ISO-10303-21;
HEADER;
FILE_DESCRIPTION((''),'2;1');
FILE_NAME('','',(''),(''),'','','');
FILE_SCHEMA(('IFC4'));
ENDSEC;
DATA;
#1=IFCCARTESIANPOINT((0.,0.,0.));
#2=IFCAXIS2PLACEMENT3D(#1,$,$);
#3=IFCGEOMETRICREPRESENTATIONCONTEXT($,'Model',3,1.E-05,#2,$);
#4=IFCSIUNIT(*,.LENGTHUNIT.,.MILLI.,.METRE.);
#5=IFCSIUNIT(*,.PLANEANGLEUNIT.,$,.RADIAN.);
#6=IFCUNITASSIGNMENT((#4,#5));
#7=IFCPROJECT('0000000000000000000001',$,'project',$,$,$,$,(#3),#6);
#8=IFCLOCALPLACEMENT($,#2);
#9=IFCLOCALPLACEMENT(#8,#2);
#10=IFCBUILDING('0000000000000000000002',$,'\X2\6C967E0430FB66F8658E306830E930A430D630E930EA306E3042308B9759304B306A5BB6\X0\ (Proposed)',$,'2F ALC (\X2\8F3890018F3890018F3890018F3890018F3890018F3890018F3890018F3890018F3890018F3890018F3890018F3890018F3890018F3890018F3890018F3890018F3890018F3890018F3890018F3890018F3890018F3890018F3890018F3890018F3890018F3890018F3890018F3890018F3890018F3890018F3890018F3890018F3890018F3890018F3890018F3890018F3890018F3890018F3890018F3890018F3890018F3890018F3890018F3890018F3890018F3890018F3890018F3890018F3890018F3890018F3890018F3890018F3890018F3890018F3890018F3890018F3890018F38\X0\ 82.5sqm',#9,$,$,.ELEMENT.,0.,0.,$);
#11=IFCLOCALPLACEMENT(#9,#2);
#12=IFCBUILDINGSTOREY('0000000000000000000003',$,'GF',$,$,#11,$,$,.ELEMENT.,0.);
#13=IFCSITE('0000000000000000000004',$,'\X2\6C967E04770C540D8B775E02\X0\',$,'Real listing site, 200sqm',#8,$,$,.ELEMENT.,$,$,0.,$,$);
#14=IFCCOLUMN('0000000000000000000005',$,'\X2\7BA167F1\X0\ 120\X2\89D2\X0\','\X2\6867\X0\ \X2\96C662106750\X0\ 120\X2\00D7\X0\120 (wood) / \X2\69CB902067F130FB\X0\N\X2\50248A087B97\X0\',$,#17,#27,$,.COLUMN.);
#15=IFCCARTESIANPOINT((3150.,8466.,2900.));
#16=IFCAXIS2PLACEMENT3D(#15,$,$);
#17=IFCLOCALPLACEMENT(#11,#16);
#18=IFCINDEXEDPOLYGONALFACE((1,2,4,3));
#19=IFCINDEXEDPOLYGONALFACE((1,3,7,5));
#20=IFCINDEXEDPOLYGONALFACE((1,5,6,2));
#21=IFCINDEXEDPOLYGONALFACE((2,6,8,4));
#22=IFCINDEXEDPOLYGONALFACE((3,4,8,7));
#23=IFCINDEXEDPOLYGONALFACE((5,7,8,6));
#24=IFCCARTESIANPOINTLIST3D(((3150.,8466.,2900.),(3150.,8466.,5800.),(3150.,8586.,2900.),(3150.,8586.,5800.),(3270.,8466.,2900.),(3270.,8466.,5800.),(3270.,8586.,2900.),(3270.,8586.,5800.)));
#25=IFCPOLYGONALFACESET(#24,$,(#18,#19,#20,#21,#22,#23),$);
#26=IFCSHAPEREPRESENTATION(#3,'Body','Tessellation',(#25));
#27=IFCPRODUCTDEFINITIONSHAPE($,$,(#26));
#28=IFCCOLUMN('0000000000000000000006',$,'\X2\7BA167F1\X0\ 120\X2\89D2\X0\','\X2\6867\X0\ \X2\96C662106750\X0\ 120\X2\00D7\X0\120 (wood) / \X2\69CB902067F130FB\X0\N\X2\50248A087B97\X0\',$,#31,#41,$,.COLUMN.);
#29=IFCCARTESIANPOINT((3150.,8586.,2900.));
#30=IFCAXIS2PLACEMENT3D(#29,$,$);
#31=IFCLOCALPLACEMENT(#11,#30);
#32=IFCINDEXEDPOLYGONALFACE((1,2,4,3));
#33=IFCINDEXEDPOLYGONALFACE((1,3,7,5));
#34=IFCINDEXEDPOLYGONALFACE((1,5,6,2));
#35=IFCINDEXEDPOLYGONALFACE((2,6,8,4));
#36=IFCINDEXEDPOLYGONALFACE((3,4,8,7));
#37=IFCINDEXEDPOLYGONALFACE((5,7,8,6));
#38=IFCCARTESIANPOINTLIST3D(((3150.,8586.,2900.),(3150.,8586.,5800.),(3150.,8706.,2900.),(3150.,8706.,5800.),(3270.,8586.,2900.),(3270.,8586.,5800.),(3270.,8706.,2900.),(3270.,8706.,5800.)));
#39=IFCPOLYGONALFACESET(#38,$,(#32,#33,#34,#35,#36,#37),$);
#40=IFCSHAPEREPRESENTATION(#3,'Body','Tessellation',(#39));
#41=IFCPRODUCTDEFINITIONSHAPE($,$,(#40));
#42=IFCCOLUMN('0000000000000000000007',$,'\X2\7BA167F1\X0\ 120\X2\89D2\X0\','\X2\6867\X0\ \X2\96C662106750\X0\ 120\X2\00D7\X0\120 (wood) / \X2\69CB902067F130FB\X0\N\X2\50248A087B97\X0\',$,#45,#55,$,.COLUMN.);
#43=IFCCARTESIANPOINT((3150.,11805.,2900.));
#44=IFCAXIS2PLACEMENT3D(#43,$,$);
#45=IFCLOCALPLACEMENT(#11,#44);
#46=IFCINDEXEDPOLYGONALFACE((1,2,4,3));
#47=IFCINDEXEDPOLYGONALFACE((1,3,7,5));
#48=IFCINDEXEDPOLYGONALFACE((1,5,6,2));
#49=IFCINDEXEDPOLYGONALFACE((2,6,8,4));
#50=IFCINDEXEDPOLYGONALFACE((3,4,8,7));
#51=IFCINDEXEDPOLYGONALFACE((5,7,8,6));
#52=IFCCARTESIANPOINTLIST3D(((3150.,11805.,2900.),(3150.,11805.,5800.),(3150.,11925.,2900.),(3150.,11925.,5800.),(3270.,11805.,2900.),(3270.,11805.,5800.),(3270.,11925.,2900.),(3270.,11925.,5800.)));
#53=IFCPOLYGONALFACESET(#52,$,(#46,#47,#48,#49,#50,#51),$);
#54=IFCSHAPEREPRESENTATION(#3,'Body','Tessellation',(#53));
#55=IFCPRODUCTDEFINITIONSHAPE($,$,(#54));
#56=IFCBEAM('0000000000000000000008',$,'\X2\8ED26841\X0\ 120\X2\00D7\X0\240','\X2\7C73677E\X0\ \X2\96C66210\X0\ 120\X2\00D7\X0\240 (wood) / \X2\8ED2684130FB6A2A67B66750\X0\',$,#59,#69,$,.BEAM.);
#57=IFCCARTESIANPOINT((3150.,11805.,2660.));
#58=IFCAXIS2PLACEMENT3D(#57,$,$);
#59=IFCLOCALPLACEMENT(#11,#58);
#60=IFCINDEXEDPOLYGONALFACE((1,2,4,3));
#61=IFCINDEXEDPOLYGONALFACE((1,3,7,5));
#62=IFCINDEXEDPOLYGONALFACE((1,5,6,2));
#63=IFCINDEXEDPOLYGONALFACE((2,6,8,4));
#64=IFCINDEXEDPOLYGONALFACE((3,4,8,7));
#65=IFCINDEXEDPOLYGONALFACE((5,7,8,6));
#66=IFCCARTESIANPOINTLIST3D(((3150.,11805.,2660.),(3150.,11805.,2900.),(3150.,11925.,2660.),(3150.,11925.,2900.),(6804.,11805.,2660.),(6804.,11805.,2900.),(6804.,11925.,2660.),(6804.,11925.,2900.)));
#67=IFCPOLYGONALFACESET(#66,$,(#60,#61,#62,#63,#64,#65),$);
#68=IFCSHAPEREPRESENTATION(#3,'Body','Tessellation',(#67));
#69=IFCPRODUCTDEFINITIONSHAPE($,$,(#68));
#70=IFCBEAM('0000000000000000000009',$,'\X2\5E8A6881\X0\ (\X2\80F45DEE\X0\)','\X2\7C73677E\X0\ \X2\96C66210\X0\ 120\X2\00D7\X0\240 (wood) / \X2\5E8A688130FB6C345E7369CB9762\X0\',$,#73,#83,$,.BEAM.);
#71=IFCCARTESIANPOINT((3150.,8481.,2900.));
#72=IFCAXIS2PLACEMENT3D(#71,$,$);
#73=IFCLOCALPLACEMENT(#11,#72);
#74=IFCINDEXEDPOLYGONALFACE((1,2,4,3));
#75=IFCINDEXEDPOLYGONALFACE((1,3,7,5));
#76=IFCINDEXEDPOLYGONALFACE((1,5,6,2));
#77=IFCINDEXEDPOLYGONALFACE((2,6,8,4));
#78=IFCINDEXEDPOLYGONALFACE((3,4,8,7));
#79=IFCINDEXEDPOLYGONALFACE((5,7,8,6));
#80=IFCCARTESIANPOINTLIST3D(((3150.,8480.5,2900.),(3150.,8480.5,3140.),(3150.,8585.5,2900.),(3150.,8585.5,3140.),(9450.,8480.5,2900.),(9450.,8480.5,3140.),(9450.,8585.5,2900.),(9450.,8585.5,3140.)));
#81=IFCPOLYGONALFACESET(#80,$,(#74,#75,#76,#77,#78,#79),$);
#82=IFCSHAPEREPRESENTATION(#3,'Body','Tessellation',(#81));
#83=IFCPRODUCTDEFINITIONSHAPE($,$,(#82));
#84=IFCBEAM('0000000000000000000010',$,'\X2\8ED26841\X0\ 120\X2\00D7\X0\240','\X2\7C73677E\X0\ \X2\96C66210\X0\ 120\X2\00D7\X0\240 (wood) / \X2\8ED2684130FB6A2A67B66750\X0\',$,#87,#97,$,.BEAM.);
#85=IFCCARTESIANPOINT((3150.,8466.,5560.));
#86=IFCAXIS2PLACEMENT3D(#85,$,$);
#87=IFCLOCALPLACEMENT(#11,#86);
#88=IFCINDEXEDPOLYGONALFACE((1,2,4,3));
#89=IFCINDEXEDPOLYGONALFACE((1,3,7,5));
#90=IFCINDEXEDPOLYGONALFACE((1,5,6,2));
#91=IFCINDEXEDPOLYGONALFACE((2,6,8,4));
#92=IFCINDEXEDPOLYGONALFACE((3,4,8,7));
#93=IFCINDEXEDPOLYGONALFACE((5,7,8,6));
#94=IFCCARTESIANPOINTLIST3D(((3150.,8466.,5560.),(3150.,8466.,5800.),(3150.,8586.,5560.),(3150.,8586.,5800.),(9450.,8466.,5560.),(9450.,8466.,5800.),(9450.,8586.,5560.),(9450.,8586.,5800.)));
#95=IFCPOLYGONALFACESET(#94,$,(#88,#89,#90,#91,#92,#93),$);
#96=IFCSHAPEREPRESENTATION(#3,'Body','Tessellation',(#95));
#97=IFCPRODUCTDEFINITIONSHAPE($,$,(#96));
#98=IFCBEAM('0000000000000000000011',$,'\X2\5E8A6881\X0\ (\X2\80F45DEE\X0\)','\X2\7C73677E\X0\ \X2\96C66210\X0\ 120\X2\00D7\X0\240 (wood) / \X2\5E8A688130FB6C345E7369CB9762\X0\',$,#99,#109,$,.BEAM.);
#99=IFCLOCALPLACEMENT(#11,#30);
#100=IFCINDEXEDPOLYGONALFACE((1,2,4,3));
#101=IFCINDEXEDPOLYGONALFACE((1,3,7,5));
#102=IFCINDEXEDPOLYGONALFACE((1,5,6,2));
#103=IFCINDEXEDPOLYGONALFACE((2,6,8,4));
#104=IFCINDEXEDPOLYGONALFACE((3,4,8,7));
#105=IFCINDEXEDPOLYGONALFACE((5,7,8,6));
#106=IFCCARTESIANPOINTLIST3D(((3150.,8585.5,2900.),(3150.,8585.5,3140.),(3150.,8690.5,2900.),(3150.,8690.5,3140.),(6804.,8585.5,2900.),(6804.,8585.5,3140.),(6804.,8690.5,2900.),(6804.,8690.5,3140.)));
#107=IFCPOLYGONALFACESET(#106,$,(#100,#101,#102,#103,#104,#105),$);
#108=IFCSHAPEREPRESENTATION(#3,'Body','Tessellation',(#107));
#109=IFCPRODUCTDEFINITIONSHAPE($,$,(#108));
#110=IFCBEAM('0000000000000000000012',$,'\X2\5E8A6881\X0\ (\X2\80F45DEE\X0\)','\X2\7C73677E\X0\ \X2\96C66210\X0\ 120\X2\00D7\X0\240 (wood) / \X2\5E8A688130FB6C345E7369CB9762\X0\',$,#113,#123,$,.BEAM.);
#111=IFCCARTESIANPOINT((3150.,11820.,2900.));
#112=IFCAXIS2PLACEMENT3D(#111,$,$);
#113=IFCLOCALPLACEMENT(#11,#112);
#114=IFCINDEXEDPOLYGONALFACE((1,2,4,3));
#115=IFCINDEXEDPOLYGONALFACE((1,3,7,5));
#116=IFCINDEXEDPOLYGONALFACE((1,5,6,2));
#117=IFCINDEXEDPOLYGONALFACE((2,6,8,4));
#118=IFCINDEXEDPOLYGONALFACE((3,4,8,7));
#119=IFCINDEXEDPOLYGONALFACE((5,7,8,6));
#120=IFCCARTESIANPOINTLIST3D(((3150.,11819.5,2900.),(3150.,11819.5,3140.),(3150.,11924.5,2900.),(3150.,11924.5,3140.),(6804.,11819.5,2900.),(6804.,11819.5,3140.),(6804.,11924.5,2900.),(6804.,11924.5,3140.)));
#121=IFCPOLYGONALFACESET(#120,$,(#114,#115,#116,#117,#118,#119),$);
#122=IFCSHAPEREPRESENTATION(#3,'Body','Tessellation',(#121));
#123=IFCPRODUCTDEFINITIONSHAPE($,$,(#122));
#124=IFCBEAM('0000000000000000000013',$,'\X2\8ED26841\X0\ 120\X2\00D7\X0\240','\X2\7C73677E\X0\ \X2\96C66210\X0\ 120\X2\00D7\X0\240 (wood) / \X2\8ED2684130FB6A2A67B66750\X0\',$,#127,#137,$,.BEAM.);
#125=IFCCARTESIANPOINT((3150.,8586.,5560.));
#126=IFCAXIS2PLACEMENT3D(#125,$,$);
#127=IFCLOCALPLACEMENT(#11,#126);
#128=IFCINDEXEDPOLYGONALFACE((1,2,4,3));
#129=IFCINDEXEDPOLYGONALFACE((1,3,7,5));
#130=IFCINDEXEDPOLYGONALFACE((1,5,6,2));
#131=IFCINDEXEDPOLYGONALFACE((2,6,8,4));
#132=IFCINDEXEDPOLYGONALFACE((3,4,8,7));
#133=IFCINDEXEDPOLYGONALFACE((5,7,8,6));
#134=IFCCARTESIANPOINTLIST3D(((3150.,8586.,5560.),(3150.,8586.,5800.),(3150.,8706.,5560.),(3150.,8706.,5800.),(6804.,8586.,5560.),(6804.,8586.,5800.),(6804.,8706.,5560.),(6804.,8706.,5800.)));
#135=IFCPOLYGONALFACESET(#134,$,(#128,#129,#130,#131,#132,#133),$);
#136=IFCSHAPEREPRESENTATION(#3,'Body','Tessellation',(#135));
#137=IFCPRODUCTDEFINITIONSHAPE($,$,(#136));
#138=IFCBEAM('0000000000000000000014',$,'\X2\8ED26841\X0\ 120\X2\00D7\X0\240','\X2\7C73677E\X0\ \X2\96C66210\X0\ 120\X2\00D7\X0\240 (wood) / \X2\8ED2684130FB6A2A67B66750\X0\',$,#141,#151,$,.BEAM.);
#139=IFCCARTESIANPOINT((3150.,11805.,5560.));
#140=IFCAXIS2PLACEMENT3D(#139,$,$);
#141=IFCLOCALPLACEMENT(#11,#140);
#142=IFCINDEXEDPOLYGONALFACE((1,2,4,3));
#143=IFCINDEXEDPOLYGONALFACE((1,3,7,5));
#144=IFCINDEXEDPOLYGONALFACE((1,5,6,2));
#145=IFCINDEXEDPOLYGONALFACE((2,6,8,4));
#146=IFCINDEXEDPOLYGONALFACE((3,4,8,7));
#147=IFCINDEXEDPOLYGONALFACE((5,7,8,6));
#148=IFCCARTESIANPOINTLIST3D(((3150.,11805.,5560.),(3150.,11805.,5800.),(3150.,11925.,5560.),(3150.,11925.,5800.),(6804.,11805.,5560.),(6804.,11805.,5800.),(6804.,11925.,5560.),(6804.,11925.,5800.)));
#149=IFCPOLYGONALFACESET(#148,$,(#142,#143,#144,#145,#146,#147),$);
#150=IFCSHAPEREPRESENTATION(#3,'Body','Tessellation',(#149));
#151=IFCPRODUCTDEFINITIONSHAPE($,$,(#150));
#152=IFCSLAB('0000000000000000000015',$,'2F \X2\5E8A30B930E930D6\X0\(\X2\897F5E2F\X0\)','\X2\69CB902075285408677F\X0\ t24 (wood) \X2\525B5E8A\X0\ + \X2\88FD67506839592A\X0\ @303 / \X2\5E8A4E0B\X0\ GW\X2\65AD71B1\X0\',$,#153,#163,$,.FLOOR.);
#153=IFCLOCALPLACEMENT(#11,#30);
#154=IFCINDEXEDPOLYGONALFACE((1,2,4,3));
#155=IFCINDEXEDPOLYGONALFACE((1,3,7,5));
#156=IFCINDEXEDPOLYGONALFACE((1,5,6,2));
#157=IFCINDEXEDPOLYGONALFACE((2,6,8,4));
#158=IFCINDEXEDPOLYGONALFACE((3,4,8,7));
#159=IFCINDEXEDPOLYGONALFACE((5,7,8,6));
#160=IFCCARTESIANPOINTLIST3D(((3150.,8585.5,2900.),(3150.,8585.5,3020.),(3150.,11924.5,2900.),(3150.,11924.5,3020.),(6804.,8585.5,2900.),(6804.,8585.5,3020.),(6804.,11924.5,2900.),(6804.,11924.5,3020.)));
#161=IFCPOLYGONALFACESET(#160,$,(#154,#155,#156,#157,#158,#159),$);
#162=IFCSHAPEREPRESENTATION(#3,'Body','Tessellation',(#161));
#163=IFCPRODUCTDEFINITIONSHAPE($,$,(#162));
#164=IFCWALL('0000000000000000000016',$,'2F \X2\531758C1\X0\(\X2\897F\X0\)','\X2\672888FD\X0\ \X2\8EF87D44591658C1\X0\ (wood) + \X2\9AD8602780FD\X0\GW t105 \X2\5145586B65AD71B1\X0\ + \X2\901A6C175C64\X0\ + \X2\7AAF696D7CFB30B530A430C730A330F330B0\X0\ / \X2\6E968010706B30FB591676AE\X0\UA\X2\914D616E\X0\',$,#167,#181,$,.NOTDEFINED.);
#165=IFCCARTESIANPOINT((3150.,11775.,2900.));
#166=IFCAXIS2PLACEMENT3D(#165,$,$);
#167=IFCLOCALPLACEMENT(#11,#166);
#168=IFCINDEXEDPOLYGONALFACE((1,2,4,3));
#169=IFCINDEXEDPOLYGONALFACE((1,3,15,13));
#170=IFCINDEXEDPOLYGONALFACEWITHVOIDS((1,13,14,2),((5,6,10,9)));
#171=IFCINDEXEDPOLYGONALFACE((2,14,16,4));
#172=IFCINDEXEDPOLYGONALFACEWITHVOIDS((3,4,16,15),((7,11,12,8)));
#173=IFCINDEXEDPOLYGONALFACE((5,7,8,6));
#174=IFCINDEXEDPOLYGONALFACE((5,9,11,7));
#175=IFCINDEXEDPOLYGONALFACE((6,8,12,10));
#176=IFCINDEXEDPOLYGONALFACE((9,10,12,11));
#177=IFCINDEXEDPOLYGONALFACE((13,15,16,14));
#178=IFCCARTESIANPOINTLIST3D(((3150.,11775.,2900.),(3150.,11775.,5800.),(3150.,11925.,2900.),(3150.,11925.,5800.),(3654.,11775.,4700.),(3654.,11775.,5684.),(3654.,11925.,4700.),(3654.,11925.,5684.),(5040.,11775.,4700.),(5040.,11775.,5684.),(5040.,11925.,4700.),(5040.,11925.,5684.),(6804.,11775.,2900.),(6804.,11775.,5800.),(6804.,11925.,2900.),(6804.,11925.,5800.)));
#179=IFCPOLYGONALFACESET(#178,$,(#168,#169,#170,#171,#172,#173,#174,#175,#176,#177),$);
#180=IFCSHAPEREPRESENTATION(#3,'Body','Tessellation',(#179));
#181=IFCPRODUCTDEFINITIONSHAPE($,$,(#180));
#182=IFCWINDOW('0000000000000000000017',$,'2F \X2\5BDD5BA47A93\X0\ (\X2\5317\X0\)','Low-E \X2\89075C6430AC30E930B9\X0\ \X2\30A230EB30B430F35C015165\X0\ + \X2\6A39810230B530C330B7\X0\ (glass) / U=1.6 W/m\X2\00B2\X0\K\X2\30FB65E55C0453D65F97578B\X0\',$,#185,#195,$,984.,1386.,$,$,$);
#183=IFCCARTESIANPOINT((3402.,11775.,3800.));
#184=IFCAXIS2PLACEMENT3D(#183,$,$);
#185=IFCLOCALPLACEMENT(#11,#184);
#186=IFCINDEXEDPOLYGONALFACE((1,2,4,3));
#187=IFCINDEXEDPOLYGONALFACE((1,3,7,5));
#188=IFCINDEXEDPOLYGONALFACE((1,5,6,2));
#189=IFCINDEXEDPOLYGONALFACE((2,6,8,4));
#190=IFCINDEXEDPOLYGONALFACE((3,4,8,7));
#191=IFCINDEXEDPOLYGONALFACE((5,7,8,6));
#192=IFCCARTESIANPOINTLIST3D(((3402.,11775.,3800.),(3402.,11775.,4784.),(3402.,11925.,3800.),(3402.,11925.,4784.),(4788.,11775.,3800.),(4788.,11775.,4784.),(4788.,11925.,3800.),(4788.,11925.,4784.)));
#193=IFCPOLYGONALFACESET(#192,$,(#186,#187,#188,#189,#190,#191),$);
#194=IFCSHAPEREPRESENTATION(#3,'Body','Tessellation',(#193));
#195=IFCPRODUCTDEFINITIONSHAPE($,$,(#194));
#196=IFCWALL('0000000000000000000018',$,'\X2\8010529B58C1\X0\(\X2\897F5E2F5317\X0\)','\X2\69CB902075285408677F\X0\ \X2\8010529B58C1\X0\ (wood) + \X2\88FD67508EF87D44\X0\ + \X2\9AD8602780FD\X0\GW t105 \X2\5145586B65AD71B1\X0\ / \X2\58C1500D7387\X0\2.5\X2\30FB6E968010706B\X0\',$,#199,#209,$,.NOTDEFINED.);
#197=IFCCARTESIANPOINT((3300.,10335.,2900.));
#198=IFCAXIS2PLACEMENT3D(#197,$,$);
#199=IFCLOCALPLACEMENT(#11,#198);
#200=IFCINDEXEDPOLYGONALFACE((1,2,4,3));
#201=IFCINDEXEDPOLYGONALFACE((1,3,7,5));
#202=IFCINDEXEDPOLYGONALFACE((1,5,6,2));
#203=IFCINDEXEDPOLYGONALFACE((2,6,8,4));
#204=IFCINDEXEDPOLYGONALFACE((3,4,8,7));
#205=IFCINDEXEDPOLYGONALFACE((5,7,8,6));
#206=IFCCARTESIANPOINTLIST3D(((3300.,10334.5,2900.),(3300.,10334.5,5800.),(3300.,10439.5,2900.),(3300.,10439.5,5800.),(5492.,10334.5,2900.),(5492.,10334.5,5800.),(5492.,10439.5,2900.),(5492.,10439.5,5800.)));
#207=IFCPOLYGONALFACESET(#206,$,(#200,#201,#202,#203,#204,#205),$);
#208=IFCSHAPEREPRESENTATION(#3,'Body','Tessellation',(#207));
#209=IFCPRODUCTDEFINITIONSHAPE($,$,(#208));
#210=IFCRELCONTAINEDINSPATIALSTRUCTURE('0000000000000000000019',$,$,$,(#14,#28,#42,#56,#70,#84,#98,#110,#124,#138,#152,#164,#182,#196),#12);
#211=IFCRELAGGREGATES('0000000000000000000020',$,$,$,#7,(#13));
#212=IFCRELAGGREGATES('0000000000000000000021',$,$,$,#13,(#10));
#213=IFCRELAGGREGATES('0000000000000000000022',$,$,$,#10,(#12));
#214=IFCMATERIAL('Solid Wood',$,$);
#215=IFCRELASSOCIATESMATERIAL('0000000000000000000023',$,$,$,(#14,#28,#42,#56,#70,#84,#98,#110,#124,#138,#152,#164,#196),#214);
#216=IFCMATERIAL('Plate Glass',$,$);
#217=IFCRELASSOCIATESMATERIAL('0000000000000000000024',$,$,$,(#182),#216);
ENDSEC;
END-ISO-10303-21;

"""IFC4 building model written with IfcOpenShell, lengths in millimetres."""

from ifc_helpers import new_model, si_unit, frame, frame_2d, origin, place, context, project, spatial, rectangle, extrude, material, element, fill, save


model = new_model("IFC4")

# Units and contexts
model_context = context("Model", 3, precision=1e-05, world=origin())
ifc_project = project(units=[si_unit("LENGTHUNIT", "METRE", prefix="MILLI"), si_unit("PLANEANGLEUNIT", "RADIAN")], contexts=[model_context])

# Site, building, storey
site_placement = place(None, origin())
site = spatial("IfcSite", under=ifc_project, at=site_placement, Name="沖縄県名護市", ObjectType="Real listing site, 200sqm", CompositionType="ELEMENT", RefElevation=0.0)
building_placement = place(site_placement, origin())
building = spatial("IfcBuilding", under=site, at=building_placement, Name="沖縄・書斎とライブラリのある静かな家 (Proposed)", ObjectType="2F ALC (輸送輸送輸送輸送輸送輸送輸送輸送輸送輸送輸送輸送輸送輸送輸送輸送輸送輸送輸送輸送輸送輸送輸送輸送輸送輸送輸送輸送輸送輸送輸送輸送輸送輸送輸送輸送輸送輸送輸送輸送輸送輸送輸送輸送輸送輸送輸送輸送輸送輸送輸送輸送輸送輸送輸送輸送輸送輸 82.5sqm", CompositionType="ELEMENT", ElevationOfRefHeight=0.0, ElevationOfTerrain=0.0)
storey_placement = place(building_placement, origin())
storey = spatial("IfcBuildingStorey", under=building, at=storey_placement, Name="GF", CompositionType="ELEMENT", Elevation=0.0)

# Columns
ifc_material_1 = material(Name="Solid Wood")
column_1_placement = place(storey_placement, frame((3150.0, 8466.0, 2900.0)))
element("IfcColumn", 1, at=column_1_placement, inside=storey, material=ifc_material_1, Name="管柱 120角", Description="桧 集成材 120×120 (wood) / 構造柱・N値計算", PredefinedType="COLUMN", context=model_context, shape_type="SweptSolid", body=[
    extrude(rectangle(XDim=120.0, YDim=120.0, at=frame_2d((60.0, 60.0))), frame((3150.0, 8466.0, 2900.0)), (0.0, 0.0, 1.0), 2900.0),
])
column_2_placement = place(storey_placement, frame((3150.0, 8586.0, 2900.0)))
element("IfcColumn", 2, at=column_2_placement, inside=storey, material=ifc_material_1, Name="管柱 120角", Description="桧 集成材 120×120 (wood) / 構造柱・N値計算", PredefinedType="COLUMN", context=model_context, shape_type="SweptSolid", body=[
    extrude(rectangle(XDim=120.0, YDim=120.0, at=frame_2d((60.0, 60.0))), frame((3150.0, 8586.0, 2900.0)), (0.0, 0.0, 1.0), 2900.0),
])
column_3_placement = place(storey_placement, frame((3150.0, 11805.0, 2900.0)))
element("IfcColumn", 3, at=column_3_placement, inside=storey, material=ifc_material_1, Name="管柱 120角", Description="桧 集成材 120×120 (wood) / 構造柱・N値計算", PredefinedType="COLUMN", context=model_context, shape_type="SweptSolid", body=[
    extrude(rectangle(XDim=120.0, YDim=120.0, at=frame_2d((60.0, 60.0))), frame((3150.0, 11805.0, 2900.0)), (0.0, 0.0, 1.0), 2900.0),
])

# Beams
beam_1_placement = place(storey_placement, frame((3150.0, 11805.0, 2660.0)))
element("IfcBeam", 4, at=beam_1_placement, inside=storey, material=ifc_material_1, Name="軒桁 120×240", Description="米松 集成 120×240 (wood) / 軒桁・横架材", PredefinedType="BEAM", context=model_context, shape_type="SweptSolid", body=[
    extrude(rectangle(XDim=3654.0, YDim=120.0, at=frame_2d((1827.0, 60.0))), frame((3150.0, 11805.0, 2660.0)), (0.0, 0.0, 1.0), 240.0),
])
beam_2_placement = place(storey_placement, frame((3150.0, 8481.0, 2900.0)))
element("IfcBeam", 5, at=beam_2_placement, inside=storey, material=ifc_material_1, Name="床梁 (胴差)", Description="米松 集成 120×240 (wood) / 床梁・水平構面", PredefinedType="BEAM", context=model_context, shape_type="SweptSolid", body=[
    extrude(rectangle(XDim=6300.0, YDim=105.0, at=frame_2d((3150.0, 52.0))), frame((3150.0, 8481.0, 2900.0)), (0.0, 0.0, 1.0), 240.0),
])
beam_3_placement = place(storey_placement, frame((3150.0, 8466.0, 5560.0)))
element("IfcBeam", 6, at=beam_3_placement, inside=storey, material=ifc_material_1, Name="軒桁 120×240", Description="米松 集成 120×240 (wood) / 軒桁・横架材", PredefinedType="BEAM", context=model_context, shape_type="SweptSolid", body=[
    extrude(rectangle(XDim=6300.0, YDim=120.0, at=frame_2d((3150.0, 60.0))), frame((3150.0, 8466.0, 5560.0)), (0.0, 0.0, 1.0), 240.0),
])
beam_4_placement = place(storey_placement, frame((3150.0, 8586.0, 2900.0)))
element("IfcBeam", 7, at=beam_4_placement, inside=storey, material=ifc_material_1, Name="床梁 (胴差)", Description="米松 集成 120×240 (wood) / 床梁・水平構面", PredefinedType="BEAM", context=model_context, shape_type="SweptSolid", body=[
    extrude(rectangle(XDim=3654.0, YDim=105.0, at=frame_2d((1827.0, 52.0))), frame((3150.0, 8586.0, 2900.0)), (0.0, 0.0, 1.0), 240.0),
])
beam_5_placement = place(storey_placement, frame((3150.0, 11820.0, 2900.0)))
element("IfcBeam", 8, at=beam_5_placement, inside=storey, material=ifc_material_1, Name="床梁 (胴差)", Description="米松 集成 120×240 (wood) / 床梁・水平構面", PredefinedType="BEAM", context=model_context, shape_type="SweptSolid", body=[
    extrude(rectangle(XDim=3654.0, YDim=105.0, at=frame_2d((1827.0, 52.0))), frame((3150.0, 11820.0, 2900.0)), (0.0, 0.0, 1.0), 240.0),
])
beam_6_placement = place(storey_placement, frame((3150.0, 8586.0, 5560.0)))
element("IfcBeam", 9, at=beam_6_placement, inside=storey, material=ifc_material_1, Name="軒桁 120×240", Description="米松 集成 120×240 (wood) / 軒桁・横架材", PredefinedType="BEAM", context=model_context, shape_type="SweptSolid", body=[
    extrude(rectangle(XDim=3654.0, YDim=120.0, at=frame_2d((1827.0, 60.0))), frame((3150.0, 8586.0, 5560.0)), (0.0, 0.0, 1.0), 240.0),
])
beam_7_placement = place(storey_placement, frame((3150.0, 11805.0, 5560.0)))
element("IfcBeam", 10, at=beam_7_placement, inside=storey, material=ifc_material_1, Name="軒桁 120×240", Description="米松 集成 120×240 (wood) / 軒桁・横架材", PredefinedType="BEAM", context=model_context, shape_type="SweptSolid", body=[
    extrude(rectangle(XDim=3654.0, YDim=120.0, at=frame_2d((1827.0, 60.0))), frame((3150.0, 11805.0, 5560.0)), (0.0, 0.0, 1.0), 240.0),
])

# Slab
slab_placement = place(storey_placement, frame((3150.0, 8586.0, 2900.0)))
element("IfcSlab", 11, at=slab_placement, inside=storey, material=ifc_material_1, Name="2F 床スラブ(西帯)", Description="構造用合板 t24 (wood) 剛床 + 製材根太 @303 / 床下 GW断熱", PredefinedType="FLOOR", context=model_context, shape_type="SweptSolid", body=[
    extrude(rectangle(XDim=3654.0, YDim=3339.0, at=frame_2d((1827.0, 1669.0))), frame((3150.0, 8586.0, 2900.0)), (0.0, 0.0, 1.0), 120.0),
])

# Wall, opening, window
wall_1_placement = place(storey_placement, frame((3150.0, 11775.0, 2900.0)))
wall_1 = element("IfcWall", 12, at=wall_1_placement, inside=storey, material=ifc_material_1, Name="2F 北壁(西)", Description="木製 軸組外壁 (wood) + 高性能GW t105 充填断熱 + 通気層 + 窯業系サイディング / 準耐火・外皮UA配慮", PredefinedType="NOTDEFINED", context=model_context, shape_type="SweptSolid", body=[
    extrude(rectangle(XDim=3654.0, YDim=150.0, at=frame_2d((1827.0, 75.0))), frame((3150.0, 11775.0, 2900.0)), (0.0, 0.0, 1.0), 2900.0),
])
opening_placement = place(storey_placement, frame((3402.0, 11775.0, 3800.0)))
opening = element("IfcOpeningElement", 13, at=opening_placement, cuts=wall_1, PredefinedType="NOTDEFINED", context=model_context, shape_type="SweptSolid", body=[
    extrude(rectangle(XDim=1386.0, YDim=150.0, at=frame_2d((693.0, 75.0))), frame((3402.0, 11775.0, 3800.0)), (0.0, 0.0, 1.0), 984.0),
])
ifc_material_2 = material(Name="Plate Glass")
window_placement = place(storey_placement, frame((3402.0, 11775.0, 3800.0)))
window = element("IfcWindow", 14, at=window_placement, inside=storey, material=ifc_material_2, Name="2F 寝室窓 (北)", Description="Low-E 複層ガラス アルゴン封入 + 樹脂サッシ (glass) / U=1.6 W/m²K・日射取得型", OverallHeight=984.0, OverallWidth=1386.0, context=model_context, shape_type="SweptSolid", body=[
    extrude(rectangle(XDim=1386.0, YDim=150.0, at=frame_2d((693.0, 75.0))), frame((3402.0, 11775.0, 3800.0)), (0.0, 0.0, 1.0), 984.0),
])
fill(opening, window)

# Wall
wall_2_placement = place(storey_placement, frame((3300.0, 10335.0, 2900.0)))
element("IfcWall", 15, at=wall_2_placement, inside=storey, material=ifc_material_1, Name="耐力壁(西帯北)", Description="構造用合板 耐力壁 (wood) + 製材軸組 + 高性能GW t105 充填断熱 / 壁倍率2.5・準耐火", PredefinedType="NOTDEFINED", context=model_context, shape_type="SweptSolid", body=[
    extrude(rectangle(XDim=2192.0, YDim=105.0, at=frame_2d((1096.0, 52.0))), frame((3300.0, 10335.0, 2900.0)), (0.0, 0.0, 1.0), 2900.0),
])

save(model, "model.ifc")
